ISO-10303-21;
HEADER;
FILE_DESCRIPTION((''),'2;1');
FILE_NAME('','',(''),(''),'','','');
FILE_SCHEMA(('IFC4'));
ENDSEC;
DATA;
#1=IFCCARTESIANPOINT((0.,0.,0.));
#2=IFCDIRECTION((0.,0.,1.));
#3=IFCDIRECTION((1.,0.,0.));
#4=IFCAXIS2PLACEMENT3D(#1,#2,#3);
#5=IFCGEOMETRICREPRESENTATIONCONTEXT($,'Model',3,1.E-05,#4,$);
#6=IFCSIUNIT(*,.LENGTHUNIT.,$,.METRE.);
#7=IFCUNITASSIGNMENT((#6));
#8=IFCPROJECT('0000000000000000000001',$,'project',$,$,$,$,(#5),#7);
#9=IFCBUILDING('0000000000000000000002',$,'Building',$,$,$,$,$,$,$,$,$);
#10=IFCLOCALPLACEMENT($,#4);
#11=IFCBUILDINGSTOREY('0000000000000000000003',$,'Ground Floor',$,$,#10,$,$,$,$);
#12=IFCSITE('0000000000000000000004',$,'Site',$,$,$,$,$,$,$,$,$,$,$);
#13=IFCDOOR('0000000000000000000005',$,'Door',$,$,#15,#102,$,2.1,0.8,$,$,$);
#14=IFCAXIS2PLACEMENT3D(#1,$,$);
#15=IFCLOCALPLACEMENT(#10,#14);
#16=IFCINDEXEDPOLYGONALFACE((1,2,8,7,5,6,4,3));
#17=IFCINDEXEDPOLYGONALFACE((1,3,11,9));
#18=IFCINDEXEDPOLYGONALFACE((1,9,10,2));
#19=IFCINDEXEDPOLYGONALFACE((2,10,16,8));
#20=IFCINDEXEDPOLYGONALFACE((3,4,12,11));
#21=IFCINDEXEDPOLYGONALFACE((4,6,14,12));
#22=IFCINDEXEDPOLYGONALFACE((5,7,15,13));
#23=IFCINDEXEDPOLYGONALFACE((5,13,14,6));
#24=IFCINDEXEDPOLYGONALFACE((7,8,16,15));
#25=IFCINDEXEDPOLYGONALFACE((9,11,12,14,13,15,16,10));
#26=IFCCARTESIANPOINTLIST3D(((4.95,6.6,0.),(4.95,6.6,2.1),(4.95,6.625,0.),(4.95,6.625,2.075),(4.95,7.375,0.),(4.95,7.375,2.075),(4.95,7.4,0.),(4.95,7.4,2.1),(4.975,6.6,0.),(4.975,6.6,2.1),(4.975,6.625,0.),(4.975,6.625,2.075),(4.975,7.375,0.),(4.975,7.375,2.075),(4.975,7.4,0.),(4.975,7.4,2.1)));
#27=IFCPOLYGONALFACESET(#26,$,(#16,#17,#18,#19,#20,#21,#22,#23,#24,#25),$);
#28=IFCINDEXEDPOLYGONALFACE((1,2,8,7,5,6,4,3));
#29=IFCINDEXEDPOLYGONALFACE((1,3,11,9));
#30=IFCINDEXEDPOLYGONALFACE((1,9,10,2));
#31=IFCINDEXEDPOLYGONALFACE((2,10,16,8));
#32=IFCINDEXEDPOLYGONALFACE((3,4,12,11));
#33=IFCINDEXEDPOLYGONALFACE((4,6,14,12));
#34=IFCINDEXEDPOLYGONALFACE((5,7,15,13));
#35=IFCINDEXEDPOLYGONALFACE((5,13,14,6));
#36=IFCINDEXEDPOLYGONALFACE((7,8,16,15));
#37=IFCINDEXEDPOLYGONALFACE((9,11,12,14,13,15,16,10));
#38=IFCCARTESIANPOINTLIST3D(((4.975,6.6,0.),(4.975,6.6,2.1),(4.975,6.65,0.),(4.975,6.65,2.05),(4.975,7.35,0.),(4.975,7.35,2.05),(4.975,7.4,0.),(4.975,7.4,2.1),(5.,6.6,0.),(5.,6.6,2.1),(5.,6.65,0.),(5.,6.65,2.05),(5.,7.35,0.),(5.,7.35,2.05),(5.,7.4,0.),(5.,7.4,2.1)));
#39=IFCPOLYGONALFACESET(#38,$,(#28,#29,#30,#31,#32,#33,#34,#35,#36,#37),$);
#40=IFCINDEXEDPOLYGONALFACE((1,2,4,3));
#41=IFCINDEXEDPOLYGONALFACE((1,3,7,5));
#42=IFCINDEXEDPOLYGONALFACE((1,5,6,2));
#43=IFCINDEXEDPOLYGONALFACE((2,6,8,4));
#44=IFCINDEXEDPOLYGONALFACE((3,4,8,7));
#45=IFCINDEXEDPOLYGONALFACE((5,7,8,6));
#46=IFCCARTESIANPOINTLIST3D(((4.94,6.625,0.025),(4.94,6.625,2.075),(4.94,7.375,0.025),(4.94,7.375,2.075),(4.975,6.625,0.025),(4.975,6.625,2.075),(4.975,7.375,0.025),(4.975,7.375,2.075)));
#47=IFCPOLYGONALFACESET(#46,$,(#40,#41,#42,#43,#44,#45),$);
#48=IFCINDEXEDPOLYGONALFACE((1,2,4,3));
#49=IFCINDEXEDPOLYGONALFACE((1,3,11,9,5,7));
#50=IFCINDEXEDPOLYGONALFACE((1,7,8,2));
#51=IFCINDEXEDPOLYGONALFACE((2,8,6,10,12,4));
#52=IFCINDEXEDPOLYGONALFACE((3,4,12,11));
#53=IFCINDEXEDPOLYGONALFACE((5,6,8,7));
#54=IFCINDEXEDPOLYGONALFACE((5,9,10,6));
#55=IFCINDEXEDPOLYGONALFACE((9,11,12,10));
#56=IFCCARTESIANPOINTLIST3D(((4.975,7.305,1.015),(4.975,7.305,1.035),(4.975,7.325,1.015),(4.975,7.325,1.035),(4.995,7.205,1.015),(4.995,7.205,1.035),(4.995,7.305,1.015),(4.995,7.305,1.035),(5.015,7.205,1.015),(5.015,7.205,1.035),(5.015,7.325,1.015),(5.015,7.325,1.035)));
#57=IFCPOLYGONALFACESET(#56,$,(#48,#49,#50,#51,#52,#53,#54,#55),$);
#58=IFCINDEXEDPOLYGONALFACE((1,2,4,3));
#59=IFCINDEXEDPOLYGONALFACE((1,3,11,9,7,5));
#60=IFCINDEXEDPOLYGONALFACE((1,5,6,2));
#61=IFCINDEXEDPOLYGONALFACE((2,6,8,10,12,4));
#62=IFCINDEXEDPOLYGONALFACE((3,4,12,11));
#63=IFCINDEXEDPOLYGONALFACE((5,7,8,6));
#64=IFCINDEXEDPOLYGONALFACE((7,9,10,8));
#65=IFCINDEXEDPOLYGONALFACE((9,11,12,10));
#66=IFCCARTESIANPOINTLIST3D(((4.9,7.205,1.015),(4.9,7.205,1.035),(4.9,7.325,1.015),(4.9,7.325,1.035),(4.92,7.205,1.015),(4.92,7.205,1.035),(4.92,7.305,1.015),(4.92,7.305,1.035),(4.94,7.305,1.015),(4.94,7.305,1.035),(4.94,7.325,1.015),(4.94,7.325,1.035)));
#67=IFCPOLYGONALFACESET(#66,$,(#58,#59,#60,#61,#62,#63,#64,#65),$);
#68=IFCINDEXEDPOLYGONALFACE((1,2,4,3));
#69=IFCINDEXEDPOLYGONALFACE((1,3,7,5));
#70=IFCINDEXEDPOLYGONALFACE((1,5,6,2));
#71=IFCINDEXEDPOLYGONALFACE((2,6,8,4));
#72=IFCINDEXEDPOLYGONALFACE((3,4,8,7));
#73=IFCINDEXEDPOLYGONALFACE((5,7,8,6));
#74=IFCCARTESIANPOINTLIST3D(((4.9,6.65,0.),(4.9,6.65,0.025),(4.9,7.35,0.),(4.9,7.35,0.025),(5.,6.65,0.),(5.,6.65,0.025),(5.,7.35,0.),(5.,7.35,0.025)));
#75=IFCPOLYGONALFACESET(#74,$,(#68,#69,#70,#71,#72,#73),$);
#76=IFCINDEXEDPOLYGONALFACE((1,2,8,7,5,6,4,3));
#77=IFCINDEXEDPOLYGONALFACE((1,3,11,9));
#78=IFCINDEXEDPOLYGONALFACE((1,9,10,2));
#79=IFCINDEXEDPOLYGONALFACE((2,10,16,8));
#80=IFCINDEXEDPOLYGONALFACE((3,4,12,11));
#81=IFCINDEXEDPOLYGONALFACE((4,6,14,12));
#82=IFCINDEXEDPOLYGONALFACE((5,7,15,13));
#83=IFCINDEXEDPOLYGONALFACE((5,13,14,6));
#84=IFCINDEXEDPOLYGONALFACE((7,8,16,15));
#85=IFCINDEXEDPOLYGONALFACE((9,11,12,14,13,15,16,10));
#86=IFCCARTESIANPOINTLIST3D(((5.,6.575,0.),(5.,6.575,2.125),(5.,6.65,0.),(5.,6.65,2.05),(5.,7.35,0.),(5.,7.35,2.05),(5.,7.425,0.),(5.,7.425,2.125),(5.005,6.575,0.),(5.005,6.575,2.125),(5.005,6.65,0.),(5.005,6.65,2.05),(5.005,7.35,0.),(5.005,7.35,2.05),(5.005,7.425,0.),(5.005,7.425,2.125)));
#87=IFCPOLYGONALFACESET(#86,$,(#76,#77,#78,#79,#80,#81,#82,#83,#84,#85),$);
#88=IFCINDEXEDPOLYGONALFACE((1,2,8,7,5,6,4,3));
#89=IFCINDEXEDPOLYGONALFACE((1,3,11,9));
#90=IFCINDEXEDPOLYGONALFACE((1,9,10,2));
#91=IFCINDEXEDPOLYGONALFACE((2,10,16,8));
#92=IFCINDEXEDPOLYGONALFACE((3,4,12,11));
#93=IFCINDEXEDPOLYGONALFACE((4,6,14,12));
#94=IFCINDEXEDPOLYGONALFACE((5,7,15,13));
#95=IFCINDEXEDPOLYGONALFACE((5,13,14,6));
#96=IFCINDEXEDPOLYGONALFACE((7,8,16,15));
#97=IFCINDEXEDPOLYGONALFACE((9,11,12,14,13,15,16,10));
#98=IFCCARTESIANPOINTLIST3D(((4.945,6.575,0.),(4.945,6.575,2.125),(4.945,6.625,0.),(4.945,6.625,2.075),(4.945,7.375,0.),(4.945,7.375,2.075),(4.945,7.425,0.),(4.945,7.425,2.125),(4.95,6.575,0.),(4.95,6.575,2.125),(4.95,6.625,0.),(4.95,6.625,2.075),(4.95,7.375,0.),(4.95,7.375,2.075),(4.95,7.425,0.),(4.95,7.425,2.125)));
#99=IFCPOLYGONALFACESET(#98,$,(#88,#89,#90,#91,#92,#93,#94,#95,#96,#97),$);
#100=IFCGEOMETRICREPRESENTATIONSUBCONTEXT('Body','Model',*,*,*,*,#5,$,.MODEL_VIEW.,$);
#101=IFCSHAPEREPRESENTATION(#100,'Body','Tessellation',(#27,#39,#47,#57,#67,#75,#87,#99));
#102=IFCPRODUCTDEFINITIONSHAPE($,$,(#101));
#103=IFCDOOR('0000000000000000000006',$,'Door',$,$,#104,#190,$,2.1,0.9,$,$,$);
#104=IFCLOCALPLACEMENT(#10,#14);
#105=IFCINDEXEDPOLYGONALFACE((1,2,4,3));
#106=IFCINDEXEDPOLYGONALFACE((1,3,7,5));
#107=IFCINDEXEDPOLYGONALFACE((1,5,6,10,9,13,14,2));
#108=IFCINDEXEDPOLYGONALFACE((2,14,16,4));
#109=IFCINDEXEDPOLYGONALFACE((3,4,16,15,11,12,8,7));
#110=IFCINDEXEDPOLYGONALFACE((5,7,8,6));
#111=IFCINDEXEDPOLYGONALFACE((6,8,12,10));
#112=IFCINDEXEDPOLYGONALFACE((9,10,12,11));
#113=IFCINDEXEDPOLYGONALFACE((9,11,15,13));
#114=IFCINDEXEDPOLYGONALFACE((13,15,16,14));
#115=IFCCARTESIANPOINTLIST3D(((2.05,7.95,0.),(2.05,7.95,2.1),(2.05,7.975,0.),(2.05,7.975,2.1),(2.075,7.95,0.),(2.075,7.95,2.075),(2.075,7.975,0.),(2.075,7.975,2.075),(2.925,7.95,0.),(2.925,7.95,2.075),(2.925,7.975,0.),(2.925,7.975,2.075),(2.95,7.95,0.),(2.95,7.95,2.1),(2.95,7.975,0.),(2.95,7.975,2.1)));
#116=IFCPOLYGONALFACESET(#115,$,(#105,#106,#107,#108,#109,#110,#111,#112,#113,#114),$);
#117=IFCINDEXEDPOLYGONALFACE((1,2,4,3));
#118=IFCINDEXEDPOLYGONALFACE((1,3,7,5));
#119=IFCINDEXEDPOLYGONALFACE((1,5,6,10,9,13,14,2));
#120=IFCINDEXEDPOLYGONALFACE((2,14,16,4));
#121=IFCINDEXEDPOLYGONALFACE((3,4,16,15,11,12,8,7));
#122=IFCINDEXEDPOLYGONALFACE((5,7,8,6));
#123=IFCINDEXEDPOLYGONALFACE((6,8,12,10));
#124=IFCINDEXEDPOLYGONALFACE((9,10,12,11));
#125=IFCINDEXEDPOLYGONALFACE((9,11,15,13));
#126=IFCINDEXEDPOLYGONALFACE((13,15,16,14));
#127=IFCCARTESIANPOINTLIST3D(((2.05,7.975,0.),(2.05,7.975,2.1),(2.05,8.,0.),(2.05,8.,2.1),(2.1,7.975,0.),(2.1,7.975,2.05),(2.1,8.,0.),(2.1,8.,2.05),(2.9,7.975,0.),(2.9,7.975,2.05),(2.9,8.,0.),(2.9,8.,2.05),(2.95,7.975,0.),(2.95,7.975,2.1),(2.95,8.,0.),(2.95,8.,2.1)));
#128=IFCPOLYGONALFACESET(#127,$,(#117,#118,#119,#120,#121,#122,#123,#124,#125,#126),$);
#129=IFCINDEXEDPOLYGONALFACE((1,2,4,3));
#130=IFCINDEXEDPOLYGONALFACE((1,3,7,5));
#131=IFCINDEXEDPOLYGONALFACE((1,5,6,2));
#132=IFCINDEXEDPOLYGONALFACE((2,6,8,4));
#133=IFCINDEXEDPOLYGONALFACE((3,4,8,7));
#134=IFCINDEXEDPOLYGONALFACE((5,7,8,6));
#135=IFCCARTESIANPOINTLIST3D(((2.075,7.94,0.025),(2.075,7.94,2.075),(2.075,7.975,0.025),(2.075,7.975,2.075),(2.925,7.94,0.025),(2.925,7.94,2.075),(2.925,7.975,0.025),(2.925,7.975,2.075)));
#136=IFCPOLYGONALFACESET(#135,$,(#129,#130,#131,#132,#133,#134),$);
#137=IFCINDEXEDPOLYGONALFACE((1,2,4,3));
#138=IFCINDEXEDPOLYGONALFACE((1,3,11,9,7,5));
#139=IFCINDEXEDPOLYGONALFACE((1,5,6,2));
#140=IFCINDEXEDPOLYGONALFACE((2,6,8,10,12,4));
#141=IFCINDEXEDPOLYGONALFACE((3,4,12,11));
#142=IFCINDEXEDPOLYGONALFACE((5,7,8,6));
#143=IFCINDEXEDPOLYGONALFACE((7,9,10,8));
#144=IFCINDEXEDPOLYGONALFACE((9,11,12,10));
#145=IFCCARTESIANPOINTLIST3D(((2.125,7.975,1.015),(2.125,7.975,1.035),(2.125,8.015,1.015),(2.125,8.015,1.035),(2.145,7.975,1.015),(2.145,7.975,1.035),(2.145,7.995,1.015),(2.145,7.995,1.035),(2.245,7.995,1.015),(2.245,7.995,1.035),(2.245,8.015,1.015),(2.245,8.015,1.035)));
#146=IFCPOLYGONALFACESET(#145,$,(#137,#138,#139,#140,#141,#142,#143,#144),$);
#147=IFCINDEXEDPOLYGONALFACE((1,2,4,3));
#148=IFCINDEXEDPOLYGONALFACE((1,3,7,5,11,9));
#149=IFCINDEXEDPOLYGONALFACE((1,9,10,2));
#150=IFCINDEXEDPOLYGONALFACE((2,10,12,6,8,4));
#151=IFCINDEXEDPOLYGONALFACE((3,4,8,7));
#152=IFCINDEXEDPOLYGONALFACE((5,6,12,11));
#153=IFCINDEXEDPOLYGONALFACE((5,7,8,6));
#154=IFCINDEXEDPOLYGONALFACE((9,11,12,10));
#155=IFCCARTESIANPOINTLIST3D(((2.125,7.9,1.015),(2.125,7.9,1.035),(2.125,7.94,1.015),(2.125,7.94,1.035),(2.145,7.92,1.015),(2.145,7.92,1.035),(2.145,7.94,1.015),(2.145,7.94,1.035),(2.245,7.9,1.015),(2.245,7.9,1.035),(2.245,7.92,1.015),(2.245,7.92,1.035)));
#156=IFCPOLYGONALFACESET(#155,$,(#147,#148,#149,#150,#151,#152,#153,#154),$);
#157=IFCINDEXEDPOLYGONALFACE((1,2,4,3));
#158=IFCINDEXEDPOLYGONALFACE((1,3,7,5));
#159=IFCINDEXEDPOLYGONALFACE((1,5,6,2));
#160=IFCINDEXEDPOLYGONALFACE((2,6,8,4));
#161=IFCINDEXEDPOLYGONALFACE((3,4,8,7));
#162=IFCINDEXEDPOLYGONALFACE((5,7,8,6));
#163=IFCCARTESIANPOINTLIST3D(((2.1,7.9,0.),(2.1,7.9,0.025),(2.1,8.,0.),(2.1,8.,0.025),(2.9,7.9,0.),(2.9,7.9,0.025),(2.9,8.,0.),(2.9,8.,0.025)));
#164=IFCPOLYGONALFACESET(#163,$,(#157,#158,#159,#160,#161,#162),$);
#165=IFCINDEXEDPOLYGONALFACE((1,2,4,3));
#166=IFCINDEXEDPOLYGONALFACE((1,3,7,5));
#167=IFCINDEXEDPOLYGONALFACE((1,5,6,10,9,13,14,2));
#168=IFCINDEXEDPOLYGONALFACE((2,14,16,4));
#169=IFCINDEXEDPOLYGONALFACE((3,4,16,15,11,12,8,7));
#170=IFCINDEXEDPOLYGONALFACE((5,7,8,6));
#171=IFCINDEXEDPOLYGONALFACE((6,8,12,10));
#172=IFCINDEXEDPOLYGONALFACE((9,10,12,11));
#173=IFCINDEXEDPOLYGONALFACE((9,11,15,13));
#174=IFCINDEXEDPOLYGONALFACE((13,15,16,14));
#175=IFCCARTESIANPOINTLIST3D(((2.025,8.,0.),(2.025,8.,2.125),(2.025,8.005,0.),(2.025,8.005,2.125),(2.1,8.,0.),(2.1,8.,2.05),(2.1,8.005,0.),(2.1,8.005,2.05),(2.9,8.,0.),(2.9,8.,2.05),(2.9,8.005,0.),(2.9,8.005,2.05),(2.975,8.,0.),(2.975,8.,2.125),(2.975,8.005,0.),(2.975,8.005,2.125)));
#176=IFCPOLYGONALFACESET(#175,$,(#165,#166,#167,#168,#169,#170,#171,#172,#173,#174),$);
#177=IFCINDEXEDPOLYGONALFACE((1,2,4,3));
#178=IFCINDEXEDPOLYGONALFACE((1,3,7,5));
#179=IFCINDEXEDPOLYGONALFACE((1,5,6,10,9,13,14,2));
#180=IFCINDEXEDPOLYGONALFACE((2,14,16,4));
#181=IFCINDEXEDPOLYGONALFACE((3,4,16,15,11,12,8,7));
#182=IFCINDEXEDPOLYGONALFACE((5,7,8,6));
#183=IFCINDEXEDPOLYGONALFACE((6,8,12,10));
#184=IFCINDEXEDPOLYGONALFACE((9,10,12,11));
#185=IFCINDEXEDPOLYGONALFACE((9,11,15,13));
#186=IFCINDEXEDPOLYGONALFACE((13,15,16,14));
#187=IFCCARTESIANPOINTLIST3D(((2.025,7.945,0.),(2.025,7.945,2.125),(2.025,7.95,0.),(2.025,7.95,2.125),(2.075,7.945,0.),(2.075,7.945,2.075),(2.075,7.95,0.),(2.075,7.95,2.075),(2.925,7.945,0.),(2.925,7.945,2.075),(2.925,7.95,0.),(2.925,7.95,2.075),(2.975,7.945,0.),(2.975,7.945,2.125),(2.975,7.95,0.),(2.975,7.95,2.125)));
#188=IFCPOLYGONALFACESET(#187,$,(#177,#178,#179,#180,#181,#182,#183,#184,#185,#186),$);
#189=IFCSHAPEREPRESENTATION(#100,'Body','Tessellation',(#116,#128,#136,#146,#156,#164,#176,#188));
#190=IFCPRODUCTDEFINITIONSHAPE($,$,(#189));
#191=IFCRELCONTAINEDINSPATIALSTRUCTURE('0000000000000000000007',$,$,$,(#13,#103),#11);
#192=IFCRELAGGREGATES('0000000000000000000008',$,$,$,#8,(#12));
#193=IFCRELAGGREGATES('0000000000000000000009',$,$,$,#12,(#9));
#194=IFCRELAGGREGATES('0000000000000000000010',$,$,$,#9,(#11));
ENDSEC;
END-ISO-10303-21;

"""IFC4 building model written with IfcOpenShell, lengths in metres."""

from ifc_helpers import new_model, si_unit, frame, origin_with_axes, place, context, subcontext, project, spatial, line, indexed_curve, outline, extrude, element, save


model = new_model("IFC4")

# Units and contexts
model_context = context("Model", 3, precision=1e-05, world=origin_with_axes())
body_context = subcontext(model_context, "Body", "Model", "MODEL_VIEW")
ifc_project = project(units=[si_unit("LENGTHUNIT", "METRE")], contexts=[model_context])

# Site, building, storey
site = spatial("IfcSite", under=ifc_project, Name="Site")
building = spatial("IfcBuilding", under=site, Name="Building")
storey_placement = place(None, origin_with_axes())
storey = spatial("IfcBuildingStorey", under=building, at=storey_placement, Name="Ground Floor")

# Doors
door_1_placement = place(storey_placement, frame((5.0, 6.6, 0.0), z_axis=(0.0, 0.0, 1.0), x_axis=(0.0, 1.0, 0.0)))
element("IfcDoor", 1, at=door_1_placement, inside=storey, Name="Door", OverallHeight=2.1, OverallWidth=0.8, context=body_context, shape_type="SweptSolid", body=[
    extrude(outline(indexed_curve([(0.0, 0.0), (0.0, 2.1), (0.8, 2.1), (0.8, 0.0), (0.775, 0.0), (0.775, 2.075), (0.025, 2.075), (0.025, 0.0)], segments=[line(1, 2, 3, 4, 5, 6, 7, 8, 1)])), frame((0.0, 0.025, 0.0), z_axis=(0.0, -1.0, 0.0), x_axis=(1.0, 0.0, 0.0)), (0.0, 0.0, -1.0), 0.025),
    extrude(outline(indexed_curve([(0.0, 0.0), (0.0, 2.1), (0.8, 2.1), (0.8, 0.0), (0.75, 0.0), (0.75, 2.05), (0.05, 2.05), (0.05, 0.0)], segments=[line(1, 2, 3, 4, 5, 6, 7, 8, 1)])), frame((0.0, 0.0, 0.0), z_axis=(0.0, -1.0, 0.0), x_axis=(1.0, 0.0, 0.0)), (0.0, 0.0, -1.0), 0.025),
    extrude(outline(indexed_curve([(0.0, 0.0), (0.75, 0.0), (0.75, 0.035), (0.0, 0.035)], segments=[line(1, 2, 3, 4, 1)])), frame((0.025, 0.025, 0.025), z_axis=(0.0, 0.0, 1.0), x_axis=(1.0, 0.0, 0.0)), (0.0, 0.0, 1.0), 2.05),
    extrude(outline(indexed_curve([(0.0, 0.0), (0.0, -0.04), (-0.12, -0.04), (-0.12, -0.02), (-0.02, -0.02), (-0.02, 0.0)], segments=[line(1, 2, 3, 4, 5, 6, 1)])), frame((0.725, 0.025, 1.015), z_axis=(0.0, 0.0, 1.0), x_axis=(1.0, 0.0, 0.0)), (0.0, 0.0, 1.0), 0.02),
    extrude(outline(indexed_curve([(0.0, 0.0), (0.0, 0.04), (-0.12, 0.04), (-0.12, 0.02), (-0.02, 0.02), (-0.02, 0.0)], segments=[line(1, 2, 3, 4, 5, 6, 1)])), frame((0.725, 0.06, 1.015), z_axis=(0.0, 0.0, 1.0), x_axis=(1.0, 0.0, 0.0)), (0.0, 0.0, 1.0), 0.02),
    extrude(outline(indexed_curve([(0.0, 0.0), (0.7, 0.0), (0.7, 0.1), (0.0, 0.1)], segments=[line(1, 2, 3, 4, 1)])), frame((0.05, 0.0, 0.0), z_axis=(0.0, 0.0, 1.0), x_axis=(1.0, 0.0, 0.0)), (0.0, 0.0, 1.0), 0.025),
    extrude(outline(indexed_curve([(0.0, 0.0), (0.0, 2.125), (0.85, 2.125), (0.85, 0.0), (0.775, 0.0), (0.775, 2.05), (0.075, 2.05), (0.075, 0.0)], segments=[line(1, 2, 3, 4, 5, 6, 7, 8, 1)])), frame((-0.025, -0.005, 0.0), z_axis=(0.0, -1.0, 0.0), x_axis=(1.0, 0.0, 0.0)), (0.0, 0.0, -1.0), 0.005),
    extrude(outline(indexed_curve([(0.0, 0.0), (0.0, 2.125), (0.85, 2.125), (0.85, 0.0), (0.8, 0.0), (0.8, 2.075), (0.05, 2.075), (0.05, 0.0)], segments=[line(1, 2, 3, 4, 5, 6, 7, 8, 1)])), frame((-0.025, 0.05, 0.0), z_axis=(0.0, -1.0, 0.0), x_axis=(1.0, 0.0, 0.0)), (0.0, 0.0, -1.0), 0.005),
])
door_2_placement = place(storey_placement, frame((2.95, 8.0, 0.0), z_axis=(0.0, 0.0, 1.0), x_axis=(-1.0, 0.0, 0.0)))
element("IfcDoor", 2, at=door_2_placement, inside=storey, Name="Door", OverallHeight=2.1, OverallWidth=0.9, context=body_context, shape_type="SweptSolid", body=[
    extrude(outline(indexed_curve([(0.0, 0.0), (0.0, 2.1), (0.9, 2.1), (0.9, 0.0), (0.875, 0.0), (0.875, 2.075), (0.025, 2.075), (0.025, 0.0)], segments=[line(1, 2, 3, 4, 5, 6, 7, 8, 1)])), frame((0.0, 0.025, 0.0), z_axis=(0.0, -1.0, 0.0), x_axis=(1.0, 0.0, 0.0)), (0.0, 0.0, -1.0), 0.025),
    extrude(outline(indexed_curve([(0.0, 0.0), (0.0, 2.1), (0.9, 2.1), (0.9, 0.0), (0.85, 0.0), (0.85, 2.05), (0.05, 2.05), (0.05, 0.0)], segments=[line(1, 2, 3, 4, 5, 6, 7, 8, 1)])), frame((0.0, 0.0, 0.0), z_axis=(0.0, -1.0, 0.0), x_axis=(1.0, 0.0, 0.0)), (0.0, 0.0, -1.0), 0.025),
    extrude(outline(indexed_curve([(0.0, 0.0), (0.85, 0.0), (0.85, 0.035), (0.0, 0.035)], segments=[line(1, 2, 3, 4, 1)])), frame((0.025, 0.025, 0.025), z_axis=(0.0, 0.0, 1.0), x_axis=(1.0, 0.0, 0.0)), (0.0, 0.0, 1.0), 2.05),
    extrude(outline(indexed_curve([(0.0, 0.0), (0.0, -0.04), (-0.12, -0.04), (-0.12, -0.02), (-0.02, -0.02), (-0.02, 0.0)], segments=[line(1, 2, 3, 4, 5, 6, 1)])), frame((0.825, 0.025, 1.015), z_axis=(0.0, 0.0, 1.0), x_axis=(1.0, 0.0, 0.0)), (0.0, 0.0, 1.0), 0.02),
    extrude(outline(indexed_curve([(0.0, 0.0), (0.0, 0.04), (-0.12, 0.04), (-0.12, 0.02), (-0.02, 0.02), (-0.02, 0.0)], segments=[line(1, 2, 3, 4, 5, 6, 1)])), frame((0.825, 0.06, 1.015), z_axis=(0.0, 0.0, 1.0), x_axis=(1.0, 0.0, 0.0)), (0.0, 0.0, 1.0), 0.02),
    extrude(outline(indexed_curve([(0.0, 0.0), (0.8, 0.0), (0.8, 0.1), (0.0, 0.1)], segments=[line(1, 2, 3, 4, 1)])), frame((0.05, 0.0, 0.0), z_axis=(0.0, 0.0, 1.0), x_axis=(1.0, 0.0, 0.0)), (0.0, 0.0, 1.0), 0.025),
    extrude(outline(indexed_curve([(0.0, 0.0), (0.0, 2.125), (0.95, 2.125), (0.95, 0.0), (0.875, 0.0), (0.875, 2.05), (0.075, 2.05), (0.075, 0.0)], segments=[line(1, 2, 3, 4, 5, 6, 7, 8, 1)])), frame((-0.025, -0.005, 0.0), z_axis=(0.0, -1.0, 0.0), x_axis=(1.0, 0.0, 0.0)), (0.0, 0.0, -1.0), 0.005),
    extrude(outline(indexed_curve([(0.0, 0.0), (0.0, 2.125), (0.95, 2.125), (0.95, 0.0), (0.9, 0.0), (0.9, 2.075), (0.05, 2.075), (0.05, 0.0)], segments=[line(1, 2, 3, 4, 5, 6, 7, 8, 1)])), frame((-0.025, 0.05, 0.0), z_axis=(0.0, -1.0, 0.0), x_axis=(1.0, 0.0, 0.0)), (0.0, 0.0, -1.0), 0.005),
])

save(model, "model.ifc")
